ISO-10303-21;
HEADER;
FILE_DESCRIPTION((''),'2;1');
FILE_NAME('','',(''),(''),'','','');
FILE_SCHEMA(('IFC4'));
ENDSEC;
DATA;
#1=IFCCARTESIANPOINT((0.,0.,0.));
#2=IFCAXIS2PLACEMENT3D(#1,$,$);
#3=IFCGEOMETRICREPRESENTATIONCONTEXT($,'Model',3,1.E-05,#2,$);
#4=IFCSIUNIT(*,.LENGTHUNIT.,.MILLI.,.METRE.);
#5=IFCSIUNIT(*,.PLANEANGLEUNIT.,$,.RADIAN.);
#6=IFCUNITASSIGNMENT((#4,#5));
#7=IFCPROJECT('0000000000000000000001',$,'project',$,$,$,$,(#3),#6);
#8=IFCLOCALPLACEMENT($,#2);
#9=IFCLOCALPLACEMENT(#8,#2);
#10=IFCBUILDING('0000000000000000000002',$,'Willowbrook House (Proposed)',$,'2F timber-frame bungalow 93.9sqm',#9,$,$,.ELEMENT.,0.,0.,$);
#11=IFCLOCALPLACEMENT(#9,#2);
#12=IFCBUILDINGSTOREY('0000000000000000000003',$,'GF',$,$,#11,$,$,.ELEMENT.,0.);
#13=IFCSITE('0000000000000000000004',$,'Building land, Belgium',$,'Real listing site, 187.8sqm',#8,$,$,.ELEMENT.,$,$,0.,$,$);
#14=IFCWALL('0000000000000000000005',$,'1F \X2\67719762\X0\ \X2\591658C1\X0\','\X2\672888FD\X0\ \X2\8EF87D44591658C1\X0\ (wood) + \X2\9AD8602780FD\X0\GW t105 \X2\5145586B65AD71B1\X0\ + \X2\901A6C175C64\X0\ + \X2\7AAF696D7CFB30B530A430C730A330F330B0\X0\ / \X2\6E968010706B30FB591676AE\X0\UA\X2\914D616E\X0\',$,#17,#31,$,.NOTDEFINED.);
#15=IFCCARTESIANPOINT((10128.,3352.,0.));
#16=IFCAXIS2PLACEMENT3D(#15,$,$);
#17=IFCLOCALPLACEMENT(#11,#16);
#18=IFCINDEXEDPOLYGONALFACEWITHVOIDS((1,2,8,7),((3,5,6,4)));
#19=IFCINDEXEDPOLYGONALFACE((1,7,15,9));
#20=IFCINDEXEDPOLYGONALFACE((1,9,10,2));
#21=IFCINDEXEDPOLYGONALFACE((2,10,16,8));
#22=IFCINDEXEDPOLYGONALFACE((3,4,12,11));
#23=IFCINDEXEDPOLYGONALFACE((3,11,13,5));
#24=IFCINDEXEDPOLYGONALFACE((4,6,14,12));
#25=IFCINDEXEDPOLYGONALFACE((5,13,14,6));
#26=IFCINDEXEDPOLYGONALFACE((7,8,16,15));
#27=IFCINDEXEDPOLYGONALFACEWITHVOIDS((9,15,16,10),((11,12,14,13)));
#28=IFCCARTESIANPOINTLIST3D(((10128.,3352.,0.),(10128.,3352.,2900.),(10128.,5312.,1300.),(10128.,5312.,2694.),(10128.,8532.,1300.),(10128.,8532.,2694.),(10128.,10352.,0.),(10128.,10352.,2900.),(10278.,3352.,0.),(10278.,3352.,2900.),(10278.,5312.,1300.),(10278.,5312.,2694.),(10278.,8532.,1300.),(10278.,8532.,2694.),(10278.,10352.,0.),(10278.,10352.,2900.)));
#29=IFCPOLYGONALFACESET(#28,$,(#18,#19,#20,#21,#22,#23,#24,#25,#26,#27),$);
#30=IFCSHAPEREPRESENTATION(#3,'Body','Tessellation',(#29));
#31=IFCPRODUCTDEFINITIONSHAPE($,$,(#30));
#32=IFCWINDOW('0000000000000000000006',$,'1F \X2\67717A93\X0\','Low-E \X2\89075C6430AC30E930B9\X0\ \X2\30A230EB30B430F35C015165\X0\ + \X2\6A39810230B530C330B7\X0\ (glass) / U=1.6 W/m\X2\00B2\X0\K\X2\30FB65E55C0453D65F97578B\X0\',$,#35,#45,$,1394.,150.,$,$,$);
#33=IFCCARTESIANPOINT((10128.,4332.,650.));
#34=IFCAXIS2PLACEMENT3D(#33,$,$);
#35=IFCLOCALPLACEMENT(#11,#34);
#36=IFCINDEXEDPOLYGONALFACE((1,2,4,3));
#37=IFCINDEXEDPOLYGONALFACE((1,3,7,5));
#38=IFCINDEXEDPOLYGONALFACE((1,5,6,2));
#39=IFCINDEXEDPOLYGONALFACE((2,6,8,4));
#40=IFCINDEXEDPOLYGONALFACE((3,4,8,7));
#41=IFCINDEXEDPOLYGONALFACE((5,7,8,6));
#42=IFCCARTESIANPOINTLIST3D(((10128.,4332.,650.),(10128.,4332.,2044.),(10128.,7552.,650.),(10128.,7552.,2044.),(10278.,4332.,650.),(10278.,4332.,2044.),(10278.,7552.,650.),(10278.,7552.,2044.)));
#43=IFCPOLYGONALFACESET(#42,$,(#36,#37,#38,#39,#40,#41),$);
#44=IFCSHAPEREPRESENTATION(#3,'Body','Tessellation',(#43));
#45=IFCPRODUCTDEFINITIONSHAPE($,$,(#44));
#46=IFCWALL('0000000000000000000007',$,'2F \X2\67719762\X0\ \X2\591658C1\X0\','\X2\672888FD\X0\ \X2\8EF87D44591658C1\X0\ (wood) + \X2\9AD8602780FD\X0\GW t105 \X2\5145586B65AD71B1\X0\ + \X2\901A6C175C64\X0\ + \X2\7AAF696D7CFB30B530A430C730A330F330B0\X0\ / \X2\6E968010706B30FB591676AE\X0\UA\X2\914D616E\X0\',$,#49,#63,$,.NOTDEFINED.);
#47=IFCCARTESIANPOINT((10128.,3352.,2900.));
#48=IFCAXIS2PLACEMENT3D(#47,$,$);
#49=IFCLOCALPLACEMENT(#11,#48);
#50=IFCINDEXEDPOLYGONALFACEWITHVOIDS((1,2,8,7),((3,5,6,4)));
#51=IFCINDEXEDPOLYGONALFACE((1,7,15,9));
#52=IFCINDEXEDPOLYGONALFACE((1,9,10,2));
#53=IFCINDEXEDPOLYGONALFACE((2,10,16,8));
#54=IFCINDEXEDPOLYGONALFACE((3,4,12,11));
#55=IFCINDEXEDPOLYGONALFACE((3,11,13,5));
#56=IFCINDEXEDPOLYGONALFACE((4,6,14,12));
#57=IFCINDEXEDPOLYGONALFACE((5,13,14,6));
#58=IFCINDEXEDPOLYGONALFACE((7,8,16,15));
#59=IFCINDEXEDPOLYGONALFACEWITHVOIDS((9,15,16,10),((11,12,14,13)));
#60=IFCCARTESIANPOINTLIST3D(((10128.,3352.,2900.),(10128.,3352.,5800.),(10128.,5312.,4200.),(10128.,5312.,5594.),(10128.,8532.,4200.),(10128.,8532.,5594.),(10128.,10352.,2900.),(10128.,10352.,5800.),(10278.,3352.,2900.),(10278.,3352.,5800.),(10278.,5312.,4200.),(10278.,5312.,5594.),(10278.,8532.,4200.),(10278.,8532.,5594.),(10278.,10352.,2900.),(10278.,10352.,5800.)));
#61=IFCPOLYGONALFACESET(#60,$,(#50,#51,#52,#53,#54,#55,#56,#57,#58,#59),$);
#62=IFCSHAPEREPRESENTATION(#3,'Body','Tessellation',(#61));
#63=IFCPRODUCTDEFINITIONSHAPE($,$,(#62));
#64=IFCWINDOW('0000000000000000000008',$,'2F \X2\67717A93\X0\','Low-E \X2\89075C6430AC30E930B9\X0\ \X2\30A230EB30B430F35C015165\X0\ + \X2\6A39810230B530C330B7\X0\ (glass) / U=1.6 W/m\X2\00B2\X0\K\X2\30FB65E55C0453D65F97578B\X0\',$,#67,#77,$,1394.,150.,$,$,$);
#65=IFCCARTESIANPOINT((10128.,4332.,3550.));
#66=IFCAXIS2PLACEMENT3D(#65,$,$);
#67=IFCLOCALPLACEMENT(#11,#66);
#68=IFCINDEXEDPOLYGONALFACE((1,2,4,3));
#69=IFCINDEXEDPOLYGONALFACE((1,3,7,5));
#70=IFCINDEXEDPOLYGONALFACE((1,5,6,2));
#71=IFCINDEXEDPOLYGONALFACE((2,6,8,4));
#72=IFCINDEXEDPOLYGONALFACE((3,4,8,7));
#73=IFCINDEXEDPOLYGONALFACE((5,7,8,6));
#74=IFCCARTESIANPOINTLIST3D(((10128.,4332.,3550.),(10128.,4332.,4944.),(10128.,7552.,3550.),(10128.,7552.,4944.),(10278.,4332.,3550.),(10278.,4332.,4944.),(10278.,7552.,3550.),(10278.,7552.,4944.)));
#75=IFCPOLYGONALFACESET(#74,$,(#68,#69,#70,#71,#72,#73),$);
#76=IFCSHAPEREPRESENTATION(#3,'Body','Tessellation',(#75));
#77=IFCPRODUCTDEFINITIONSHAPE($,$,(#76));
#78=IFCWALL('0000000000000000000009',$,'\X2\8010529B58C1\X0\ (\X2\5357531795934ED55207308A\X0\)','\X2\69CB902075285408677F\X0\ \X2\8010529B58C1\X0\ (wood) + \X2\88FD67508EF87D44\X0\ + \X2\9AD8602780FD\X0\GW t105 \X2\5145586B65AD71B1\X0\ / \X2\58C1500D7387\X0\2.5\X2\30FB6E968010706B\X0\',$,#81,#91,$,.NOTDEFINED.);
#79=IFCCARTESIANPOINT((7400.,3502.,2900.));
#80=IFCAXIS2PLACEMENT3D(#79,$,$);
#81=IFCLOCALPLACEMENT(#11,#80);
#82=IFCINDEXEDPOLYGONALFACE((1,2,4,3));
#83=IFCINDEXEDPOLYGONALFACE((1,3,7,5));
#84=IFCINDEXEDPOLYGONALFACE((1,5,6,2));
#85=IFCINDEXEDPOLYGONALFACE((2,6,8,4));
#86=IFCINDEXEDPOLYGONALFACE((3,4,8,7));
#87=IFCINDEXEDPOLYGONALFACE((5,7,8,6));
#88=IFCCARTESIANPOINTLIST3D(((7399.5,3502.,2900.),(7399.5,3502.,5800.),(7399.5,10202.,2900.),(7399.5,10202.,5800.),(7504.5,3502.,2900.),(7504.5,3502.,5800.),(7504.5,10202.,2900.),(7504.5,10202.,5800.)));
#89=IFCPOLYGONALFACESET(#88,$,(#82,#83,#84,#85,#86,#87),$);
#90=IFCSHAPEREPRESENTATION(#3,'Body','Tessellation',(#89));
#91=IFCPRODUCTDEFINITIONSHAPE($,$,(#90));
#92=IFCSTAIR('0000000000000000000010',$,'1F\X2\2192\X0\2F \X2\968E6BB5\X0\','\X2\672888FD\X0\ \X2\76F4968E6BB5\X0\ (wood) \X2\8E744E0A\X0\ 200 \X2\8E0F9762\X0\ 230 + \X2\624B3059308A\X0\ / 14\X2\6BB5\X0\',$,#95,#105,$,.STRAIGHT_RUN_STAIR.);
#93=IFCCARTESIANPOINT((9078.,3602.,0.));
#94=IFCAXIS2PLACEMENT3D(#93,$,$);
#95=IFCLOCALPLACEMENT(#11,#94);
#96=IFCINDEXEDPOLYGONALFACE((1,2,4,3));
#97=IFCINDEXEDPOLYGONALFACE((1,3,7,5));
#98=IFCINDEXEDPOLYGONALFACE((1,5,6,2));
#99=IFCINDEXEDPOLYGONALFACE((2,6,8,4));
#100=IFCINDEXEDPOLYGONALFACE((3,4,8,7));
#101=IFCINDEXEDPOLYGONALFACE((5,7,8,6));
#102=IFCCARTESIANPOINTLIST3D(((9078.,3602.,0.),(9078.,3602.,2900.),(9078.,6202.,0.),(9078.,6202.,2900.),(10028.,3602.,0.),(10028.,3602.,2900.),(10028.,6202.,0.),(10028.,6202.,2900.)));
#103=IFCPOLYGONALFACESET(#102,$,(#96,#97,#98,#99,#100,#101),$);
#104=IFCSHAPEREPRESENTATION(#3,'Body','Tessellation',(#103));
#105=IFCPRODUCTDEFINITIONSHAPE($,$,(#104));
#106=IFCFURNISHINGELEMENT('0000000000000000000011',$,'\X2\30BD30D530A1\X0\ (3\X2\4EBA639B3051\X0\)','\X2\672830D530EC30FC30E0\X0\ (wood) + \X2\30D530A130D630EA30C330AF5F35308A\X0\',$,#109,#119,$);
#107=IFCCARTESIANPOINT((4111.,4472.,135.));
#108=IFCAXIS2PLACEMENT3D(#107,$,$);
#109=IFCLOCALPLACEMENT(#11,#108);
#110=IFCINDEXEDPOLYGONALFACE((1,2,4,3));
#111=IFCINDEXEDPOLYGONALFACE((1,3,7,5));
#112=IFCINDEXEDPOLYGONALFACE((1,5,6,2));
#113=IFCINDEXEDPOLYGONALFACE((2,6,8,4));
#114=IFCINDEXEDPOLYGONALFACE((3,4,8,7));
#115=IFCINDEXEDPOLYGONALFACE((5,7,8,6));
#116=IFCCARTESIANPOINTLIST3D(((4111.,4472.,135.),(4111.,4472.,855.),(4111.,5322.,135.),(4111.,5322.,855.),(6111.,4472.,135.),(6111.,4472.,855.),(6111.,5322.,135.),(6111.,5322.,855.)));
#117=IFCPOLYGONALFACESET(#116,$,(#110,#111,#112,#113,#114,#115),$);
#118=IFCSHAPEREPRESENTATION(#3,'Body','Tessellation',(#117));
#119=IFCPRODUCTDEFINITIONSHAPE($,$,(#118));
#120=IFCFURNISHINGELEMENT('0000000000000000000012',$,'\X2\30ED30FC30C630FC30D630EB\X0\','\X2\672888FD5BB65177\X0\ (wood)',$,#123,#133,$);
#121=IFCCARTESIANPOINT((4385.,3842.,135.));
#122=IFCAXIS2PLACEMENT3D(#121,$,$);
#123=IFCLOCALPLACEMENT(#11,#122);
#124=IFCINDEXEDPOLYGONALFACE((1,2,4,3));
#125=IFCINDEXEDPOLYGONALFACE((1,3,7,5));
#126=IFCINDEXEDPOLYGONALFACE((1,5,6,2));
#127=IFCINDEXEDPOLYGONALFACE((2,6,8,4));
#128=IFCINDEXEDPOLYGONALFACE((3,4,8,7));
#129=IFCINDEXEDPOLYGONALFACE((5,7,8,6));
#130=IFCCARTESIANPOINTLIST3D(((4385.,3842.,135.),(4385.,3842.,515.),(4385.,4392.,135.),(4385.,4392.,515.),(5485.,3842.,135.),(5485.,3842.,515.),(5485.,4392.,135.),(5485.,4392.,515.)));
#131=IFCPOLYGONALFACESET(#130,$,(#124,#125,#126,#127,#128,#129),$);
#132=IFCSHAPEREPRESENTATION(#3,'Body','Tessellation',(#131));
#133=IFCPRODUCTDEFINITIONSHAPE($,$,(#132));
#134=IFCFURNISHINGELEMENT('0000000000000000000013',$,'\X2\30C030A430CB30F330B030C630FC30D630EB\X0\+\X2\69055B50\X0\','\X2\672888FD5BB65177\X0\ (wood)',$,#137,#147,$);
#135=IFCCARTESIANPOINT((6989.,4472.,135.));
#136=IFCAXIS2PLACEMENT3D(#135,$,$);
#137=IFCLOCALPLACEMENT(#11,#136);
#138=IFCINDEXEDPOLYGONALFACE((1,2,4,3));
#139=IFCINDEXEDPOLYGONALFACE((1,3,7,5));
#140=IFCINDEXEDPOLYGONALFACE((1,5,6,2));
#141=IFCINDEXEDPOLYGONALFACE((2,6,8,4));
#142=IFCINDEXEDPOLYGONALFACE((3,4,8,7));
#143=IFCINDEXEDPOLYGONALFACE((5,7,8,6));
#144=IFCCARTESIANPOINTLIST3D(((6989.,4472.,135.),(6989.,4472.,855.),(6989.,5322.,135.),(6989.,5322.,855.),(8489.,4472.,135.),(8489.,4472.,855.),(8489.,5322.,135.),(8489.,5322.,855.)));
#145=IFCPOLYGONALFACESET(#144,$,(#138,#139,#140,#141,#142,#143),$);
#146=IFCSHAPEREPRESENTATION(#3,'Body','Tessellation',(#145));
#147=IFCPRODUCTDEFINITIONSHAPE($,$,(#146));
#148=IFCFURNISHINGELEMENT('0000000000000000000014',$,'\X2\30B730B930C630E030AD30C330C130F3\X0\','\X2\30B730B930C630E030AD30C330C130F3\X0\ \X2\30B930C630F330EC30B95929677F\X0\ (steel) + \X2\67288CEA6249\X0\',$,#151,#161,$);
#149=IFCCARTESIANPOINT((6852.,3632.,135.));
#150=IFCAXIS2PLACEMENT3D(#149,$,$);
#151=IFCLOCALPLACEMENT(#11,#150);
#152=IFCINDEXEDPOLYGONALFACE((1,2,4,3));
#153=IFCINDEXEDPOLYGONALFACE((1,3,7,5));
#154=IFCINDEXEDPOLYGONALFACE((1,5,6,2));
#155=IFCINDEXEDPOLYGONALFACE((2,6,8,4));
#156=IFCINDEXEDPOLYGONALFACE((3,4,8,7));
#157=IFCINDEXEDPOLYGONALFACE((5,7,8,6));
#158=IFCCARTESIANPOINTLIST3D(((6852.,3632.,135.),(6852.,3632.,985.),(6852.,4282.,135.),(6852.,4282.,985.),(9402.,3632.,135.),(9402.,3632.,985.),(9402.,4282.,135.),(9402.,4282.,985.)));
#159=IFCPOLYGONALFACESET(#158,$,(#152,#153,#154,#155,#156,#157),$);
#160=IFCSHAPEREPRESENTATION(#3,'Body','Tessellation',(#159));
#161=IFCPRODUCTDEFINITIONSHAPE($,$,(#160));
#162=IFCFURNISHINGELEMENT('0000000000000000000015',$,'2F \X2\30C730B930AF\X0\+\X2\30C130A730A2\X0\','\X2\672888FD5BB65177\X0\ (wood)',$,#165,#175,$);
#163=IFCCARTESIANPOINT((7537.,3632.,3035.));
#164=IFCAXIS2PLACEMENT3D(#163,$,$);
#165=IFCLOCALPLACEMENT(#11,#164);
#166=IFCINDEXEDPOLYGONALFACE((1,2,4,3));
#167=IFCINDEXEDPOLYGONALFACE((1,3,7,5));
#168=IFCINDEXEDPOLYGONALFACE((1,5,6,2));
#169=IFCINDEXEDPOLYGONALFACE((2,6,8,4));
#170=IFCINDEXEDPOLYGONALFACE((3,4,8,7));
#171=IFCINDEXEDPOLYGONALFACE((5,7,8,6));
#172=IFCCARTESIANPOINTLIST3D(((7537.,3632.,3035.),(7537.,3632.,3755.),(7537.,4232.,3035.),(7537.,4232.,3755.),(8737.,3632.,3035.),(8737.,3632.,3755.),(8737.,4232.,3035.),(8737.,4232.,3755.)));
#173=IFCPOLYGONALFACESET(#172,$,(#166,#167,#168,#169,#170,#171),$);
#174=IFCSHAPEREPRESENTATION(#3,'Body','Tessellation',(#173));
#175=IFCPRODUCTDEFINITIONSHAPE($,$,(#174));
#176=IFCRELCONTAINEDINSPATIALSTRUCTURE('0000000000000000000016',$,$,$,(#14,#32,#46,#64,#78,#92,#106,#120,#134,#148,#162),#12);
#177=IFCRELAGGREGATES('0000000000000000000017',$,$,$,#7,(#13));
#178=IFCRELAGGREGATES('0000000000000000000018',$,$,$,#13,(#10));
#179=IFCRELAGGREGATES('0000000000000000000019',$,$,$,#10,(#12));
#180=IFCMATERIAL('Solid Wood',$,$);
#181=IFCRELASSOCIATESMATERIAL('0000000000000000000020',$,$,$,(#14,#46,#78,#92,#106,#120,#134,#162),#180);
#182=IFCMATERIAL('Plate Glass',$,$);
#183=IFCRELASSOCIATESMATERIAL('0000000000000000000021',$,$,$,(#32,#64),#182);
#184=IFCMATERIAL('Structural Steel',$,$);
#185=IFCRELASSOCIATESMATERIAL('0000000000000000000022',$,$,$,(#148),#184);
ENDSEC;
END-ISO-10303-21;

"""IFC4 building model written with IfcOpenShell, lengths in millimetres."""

from ifc_helpers import new_model, si_unit, frame, frame_2d, origin, place, context, project, spatial, rectangle, extrude, material, element, fill, save


model = new_model("IFC4")

# Units and contexts
model_context = context("Model", 3, precision=1e-05, world=origin())
ifc_project = project(units=[si_unit("LENGTHUNIT", "METRE", prefix="MILLI"), si_unit("PLANEANGLEUNIT", "RADIAN")], contexts=[model_context])

# Site, building, storey
site_placement = place(None, origin())
site = spatial("IfcSite", under=ifc_project, at=site_placement, Name="Building land, Belgium", ObjectType="Real listing site, 187.8sqm", CompositionType="ELEMENT", RefElevation=0.0)
building_placement = place(site_placement, origin())
building = spatial("IfcBuilding", under=site, at=building_placement, Name="Willowbrook House (Proposed)", ObjectType="2F timber-frame bungalow 93.9sqm", CompositionType="ELEMENT", ElevationOfRefHeight=0.0, ElevationOfTerrain=0.0)
storey_placement = place(building_placement, origin())
storey = spatial("IfcBuildingStorey", under=building, at=storey_placement, Name="GF", CompositionType="ELEMENT", Elevation=0.0)

# Wall, opening, window
ifc_material_1 = material(Name="Solid Wood")
wall_1_placement = place(storey_placement, frame((10128.0, 3352.0, 0.0)))
wall_1 = element("IfcWall", 1, at=wall_1_placement, inside=storey, material=ifc_material_1, Name="1F 東面 外壁", Description="木製 軸組外壁 (wood) + 高性能GW t105 充填断熱 + 通気層 + 窯業系サイディング / 準耐火・外皮UA配慮", PredefinedType="NOTDEFINED", context=model_context, shape_type="SweptSolid", body=[
    extrude(rectangle(XDim=150.0, YDim=7000.0, at=frame_2d((75.0, 3500.0))), frame((10128.0, 3352.0, 0.0)), (0.0, 0.0, 1.0), 2900.0),
])
opening_1_placement = place(storey_placement, frame((10128.0, 4332.0, 650.0)))
opening_1 = element("IfcOpeningElement", 2, at=opening_1_placement, cuts=wall_1, PredefinedType="NOTDEFINED", context=model_context, shape_type="SweptSolid", body=[
    extrude(rectangle(XDim=150.0, YDim=3220.0, at=frame_2d((75.0, 1610.0))), frame((10128.0, 4332.0, 650.0)), (0.0, 0.0, 1.0), 1394.0),
])
ifc_material_2 = material(Name="Plate Glass")
window_1_placement = place(storey_placement, frame((10128.0, 4332.0, 650.0)))
window_1 = element("IfcWindow", 3, at=window_1_placement, inside=storey, material=ifc_material_2, Name="1F 東窓", Description="Low-E 複層ガラス アルゴン封入 + 樹脂サッシ (glass) / U=1.6 W/m²K・日射取得型", OverallHeight=1394.0, OverallWidth=150.0, context=model_context, shape_type="SweptSolid", body=[
    extrude(rectangle(XDim=150.0, YDim=3220.0, at=frame_2d((75.0, 1610.0))), frame((10128.0, 4332.0, 650.0)), (0.0, 0.0, 1.0), 1394.0),
])
fill(opening_1, window_1)

# Wall, opening, window
wall_2_placement = place(storey_placement, frame((10128.0, 3352.0, 2900.0)))
wall_2 = element("IfcWall", 4, at=wall_2_placement, inside=storey, material=ifc_material_1, Name="2F 東面 外壁", Description="木製 軸組外壁 (wood) + 高性能GW t105 充填断熱 + 通気層 + 窯業系サイディング / 準耐火・外皮UA配慮", PredefinedType="NOTDEFINED", context=model_context, shape_type="SweptSolid", body=[
    extrude(rectangle(XDim=150.0, YDim=7000.0, at=frame_2d((75.0, 3500.0))), frame((10128.0, 3352.0, 2900.0)), (0.0, 0.0, 1.0), 2900.0),
])
opening_2_placement = place(storey_placement, frame((10128.0, 4332.0, 3550.0)))
opening_2 = element("IfcOpeningElement", 5, at=opening_2_placement, cuts=wall_2, PredefinedType="NOTDEFINED", context=model_context, shape_type="SweptSolid", body=[
    extrude(rectangle(XDim=150.0, YDim=3220.0, at=frame_2d((75.0, 1610.0))), frame((10128.0, 4332.0, 3550.0)), (0.0, 0.0, 1.0), 1394.0),
])
window_2_placement = place(storey_placement, frame((10128.0, 4332.0, 3550.0)))
window_2 = element("IfcWindow", 6, at=window_2_placement, inside=storey, material=ifc_material_2, Name="2F 東窓", Description="Low-E 複層ガラス アルゴン封入 + 樹脂サッシ (glass) / U=1.6 W/m²K・日射取得型", OverallHeight=1394.0, OverallWidth=150.0, context=model_context, shape_type="SweptSolid", body=[
    extrude(rectangle(XDim=150.0, YDim=3220.0, at=frame_2d((75.0, 1610.0))), frame((10128.0, 4332.0, 3550.0)), (0.0, 0.0, 1.0), 1394.0),
])
fill(opening_2, window_2)

# Wall
wall_3_placement = place(storey_placement, frame((7400.0, 3502.0, 2900.0)))
element("IfcWall", 7, at=wall_3_placement, inside=storey, material=ifc_material_1, Name="耐力壁 (南北間仕切り)", Description="構造用合板 耐力壁 (wood) + 製材軸組 + 高性能GW t105 充填断熱 / 壁倍率2.5・準耐火", PredefinedType="NOTDEFINED", context=model_context, shape_type="SweptSolid", body=[
    extrude(rectangle(XDim=105.0, YDim=6700.0, at=frame_2d((52.0, 3350.0))), frame((7400.0, 3502.0, 2900.0)), (0.0, 0.0, 1.0), 2900.0),
])

# Stair
stair_placement = place(storey_placement, frame((9078.0, 3602.0, 0.0)))
element("IfcStair", 8, at=stair_placement, inside=storey, material=ifc_material_1, Name="1F→2F 階段", Description="木製 直階段 (wood) 蹴上 200 踏面 230 + 手すり / 14段", PredefinedType="STRAIGHT_RUN_STAIR", context=model_context, shape_type="SweptSolid", body=[
    extrude(rectangle(XDim=950.0, YDim=2600.0, at=frame_2d((475.0, 1300.0))), frame((9078.0, 3602.0, 0.0)), (0.0, 0.0, 1.0), 2900.0),
])

# Furnishing elements
furnishing_1_placement = place(storey_placement, frame((4111.0, 4472.0, 135.0)))
element("IfcFurnishingElement", 9, at=furnishing_1_placement, inside=storey, material=ifc_material_1, Name="ソファ (3人掛け)", Description="木フレーム (wood) + ファブリック張り", context=model_context, shape_type="SweptSolid", body=[
    extrude(rectangle(XDim=2000.0, YDim=850.0, at=frame_2d((1000.0, 425.0))), frame((4111.0, 4472.0, 135.0)), (0.0, 0.0, 1.0), 720.0),
])
furnishing_2_placement = place(storey_placement, frame((4385.0, 3842.0, 135.0)))
element("IfcFurnishingElement", 10, at=furnishing_2_placement, inside=storey, material=ifc_material_1, Name="ローテーブル", Description="木製家具 (wood)", context=model_context, shape_type="SweptSolid", body=[
    extrude(rectangle(XDim=1100.0, YDim=550.0, at=frame_2d((550.0, 275.0))), frame((4385.0, 3842.0, 135.0)), (0.0, 0.0, 1.0), 380.0),
])
furnishing_3_placement = place(storey_placement, frame((6989.0, 4472.0, 135.0)))
element("IfcFurnishingElement", 11, at=furnishing_3_placement, inside=storey, material=ifc_material_1, Name="ダイニングテーブル+椅子", Description="木製家具 (wood)", context=model_context, shape_type="SweptSolid", body=[
    extrude(rectangle(XDim=1500.0, YDim=850.0, at=frame_2d((750.0, 425.0))), frame((6989.0, 4472.0, 135.0)), (0.0, 0.0, 1.0), 720.0),
])
ifc_material_3 = material(Name="Structural Steel")
furnishing_4_placement = place(storey_placement, frame((6852.0, 3632.0, 135.0)))
element("IfcFurnishingElement", 12, at=furnishing_4_placement, inside=storey, material=ifc_material_3, Name="システムキッチン", Description="システムキッチン ステンレス天板 (steel) + 木質扉", context=model_context, shape_type="SweptSolid", body=[
    extrude(rectangle(XDim=2550.0, YDim=650.0, at=frame_2d((1275.0, 325.0))), frame((6852.0, 3632.0, 135.0)), (0.0, 0.0, 1.0), 850.0),
])
furnishing_5_placement = place(storey_placement, frame((7537.0, 3632.0, 3035.0)))
element("IfcFurnishingElement", 13, at=furnishing_5_placement, inside=storey, material=ifc_material_1, Name="2F デスク+チェア", Description="木製家具 (wood)", context=model_context, shape_type="SweptSolid", body=[
    extrude(rectangle(XDim=1200.0, YDim=600.0, at=frame_2d((600.0, 300.0))), frame((7537.0, 3632.0, 3035.0)), (0.0, 0.0, 1.0), 720.0),
])

save(model, "model.ifc")
